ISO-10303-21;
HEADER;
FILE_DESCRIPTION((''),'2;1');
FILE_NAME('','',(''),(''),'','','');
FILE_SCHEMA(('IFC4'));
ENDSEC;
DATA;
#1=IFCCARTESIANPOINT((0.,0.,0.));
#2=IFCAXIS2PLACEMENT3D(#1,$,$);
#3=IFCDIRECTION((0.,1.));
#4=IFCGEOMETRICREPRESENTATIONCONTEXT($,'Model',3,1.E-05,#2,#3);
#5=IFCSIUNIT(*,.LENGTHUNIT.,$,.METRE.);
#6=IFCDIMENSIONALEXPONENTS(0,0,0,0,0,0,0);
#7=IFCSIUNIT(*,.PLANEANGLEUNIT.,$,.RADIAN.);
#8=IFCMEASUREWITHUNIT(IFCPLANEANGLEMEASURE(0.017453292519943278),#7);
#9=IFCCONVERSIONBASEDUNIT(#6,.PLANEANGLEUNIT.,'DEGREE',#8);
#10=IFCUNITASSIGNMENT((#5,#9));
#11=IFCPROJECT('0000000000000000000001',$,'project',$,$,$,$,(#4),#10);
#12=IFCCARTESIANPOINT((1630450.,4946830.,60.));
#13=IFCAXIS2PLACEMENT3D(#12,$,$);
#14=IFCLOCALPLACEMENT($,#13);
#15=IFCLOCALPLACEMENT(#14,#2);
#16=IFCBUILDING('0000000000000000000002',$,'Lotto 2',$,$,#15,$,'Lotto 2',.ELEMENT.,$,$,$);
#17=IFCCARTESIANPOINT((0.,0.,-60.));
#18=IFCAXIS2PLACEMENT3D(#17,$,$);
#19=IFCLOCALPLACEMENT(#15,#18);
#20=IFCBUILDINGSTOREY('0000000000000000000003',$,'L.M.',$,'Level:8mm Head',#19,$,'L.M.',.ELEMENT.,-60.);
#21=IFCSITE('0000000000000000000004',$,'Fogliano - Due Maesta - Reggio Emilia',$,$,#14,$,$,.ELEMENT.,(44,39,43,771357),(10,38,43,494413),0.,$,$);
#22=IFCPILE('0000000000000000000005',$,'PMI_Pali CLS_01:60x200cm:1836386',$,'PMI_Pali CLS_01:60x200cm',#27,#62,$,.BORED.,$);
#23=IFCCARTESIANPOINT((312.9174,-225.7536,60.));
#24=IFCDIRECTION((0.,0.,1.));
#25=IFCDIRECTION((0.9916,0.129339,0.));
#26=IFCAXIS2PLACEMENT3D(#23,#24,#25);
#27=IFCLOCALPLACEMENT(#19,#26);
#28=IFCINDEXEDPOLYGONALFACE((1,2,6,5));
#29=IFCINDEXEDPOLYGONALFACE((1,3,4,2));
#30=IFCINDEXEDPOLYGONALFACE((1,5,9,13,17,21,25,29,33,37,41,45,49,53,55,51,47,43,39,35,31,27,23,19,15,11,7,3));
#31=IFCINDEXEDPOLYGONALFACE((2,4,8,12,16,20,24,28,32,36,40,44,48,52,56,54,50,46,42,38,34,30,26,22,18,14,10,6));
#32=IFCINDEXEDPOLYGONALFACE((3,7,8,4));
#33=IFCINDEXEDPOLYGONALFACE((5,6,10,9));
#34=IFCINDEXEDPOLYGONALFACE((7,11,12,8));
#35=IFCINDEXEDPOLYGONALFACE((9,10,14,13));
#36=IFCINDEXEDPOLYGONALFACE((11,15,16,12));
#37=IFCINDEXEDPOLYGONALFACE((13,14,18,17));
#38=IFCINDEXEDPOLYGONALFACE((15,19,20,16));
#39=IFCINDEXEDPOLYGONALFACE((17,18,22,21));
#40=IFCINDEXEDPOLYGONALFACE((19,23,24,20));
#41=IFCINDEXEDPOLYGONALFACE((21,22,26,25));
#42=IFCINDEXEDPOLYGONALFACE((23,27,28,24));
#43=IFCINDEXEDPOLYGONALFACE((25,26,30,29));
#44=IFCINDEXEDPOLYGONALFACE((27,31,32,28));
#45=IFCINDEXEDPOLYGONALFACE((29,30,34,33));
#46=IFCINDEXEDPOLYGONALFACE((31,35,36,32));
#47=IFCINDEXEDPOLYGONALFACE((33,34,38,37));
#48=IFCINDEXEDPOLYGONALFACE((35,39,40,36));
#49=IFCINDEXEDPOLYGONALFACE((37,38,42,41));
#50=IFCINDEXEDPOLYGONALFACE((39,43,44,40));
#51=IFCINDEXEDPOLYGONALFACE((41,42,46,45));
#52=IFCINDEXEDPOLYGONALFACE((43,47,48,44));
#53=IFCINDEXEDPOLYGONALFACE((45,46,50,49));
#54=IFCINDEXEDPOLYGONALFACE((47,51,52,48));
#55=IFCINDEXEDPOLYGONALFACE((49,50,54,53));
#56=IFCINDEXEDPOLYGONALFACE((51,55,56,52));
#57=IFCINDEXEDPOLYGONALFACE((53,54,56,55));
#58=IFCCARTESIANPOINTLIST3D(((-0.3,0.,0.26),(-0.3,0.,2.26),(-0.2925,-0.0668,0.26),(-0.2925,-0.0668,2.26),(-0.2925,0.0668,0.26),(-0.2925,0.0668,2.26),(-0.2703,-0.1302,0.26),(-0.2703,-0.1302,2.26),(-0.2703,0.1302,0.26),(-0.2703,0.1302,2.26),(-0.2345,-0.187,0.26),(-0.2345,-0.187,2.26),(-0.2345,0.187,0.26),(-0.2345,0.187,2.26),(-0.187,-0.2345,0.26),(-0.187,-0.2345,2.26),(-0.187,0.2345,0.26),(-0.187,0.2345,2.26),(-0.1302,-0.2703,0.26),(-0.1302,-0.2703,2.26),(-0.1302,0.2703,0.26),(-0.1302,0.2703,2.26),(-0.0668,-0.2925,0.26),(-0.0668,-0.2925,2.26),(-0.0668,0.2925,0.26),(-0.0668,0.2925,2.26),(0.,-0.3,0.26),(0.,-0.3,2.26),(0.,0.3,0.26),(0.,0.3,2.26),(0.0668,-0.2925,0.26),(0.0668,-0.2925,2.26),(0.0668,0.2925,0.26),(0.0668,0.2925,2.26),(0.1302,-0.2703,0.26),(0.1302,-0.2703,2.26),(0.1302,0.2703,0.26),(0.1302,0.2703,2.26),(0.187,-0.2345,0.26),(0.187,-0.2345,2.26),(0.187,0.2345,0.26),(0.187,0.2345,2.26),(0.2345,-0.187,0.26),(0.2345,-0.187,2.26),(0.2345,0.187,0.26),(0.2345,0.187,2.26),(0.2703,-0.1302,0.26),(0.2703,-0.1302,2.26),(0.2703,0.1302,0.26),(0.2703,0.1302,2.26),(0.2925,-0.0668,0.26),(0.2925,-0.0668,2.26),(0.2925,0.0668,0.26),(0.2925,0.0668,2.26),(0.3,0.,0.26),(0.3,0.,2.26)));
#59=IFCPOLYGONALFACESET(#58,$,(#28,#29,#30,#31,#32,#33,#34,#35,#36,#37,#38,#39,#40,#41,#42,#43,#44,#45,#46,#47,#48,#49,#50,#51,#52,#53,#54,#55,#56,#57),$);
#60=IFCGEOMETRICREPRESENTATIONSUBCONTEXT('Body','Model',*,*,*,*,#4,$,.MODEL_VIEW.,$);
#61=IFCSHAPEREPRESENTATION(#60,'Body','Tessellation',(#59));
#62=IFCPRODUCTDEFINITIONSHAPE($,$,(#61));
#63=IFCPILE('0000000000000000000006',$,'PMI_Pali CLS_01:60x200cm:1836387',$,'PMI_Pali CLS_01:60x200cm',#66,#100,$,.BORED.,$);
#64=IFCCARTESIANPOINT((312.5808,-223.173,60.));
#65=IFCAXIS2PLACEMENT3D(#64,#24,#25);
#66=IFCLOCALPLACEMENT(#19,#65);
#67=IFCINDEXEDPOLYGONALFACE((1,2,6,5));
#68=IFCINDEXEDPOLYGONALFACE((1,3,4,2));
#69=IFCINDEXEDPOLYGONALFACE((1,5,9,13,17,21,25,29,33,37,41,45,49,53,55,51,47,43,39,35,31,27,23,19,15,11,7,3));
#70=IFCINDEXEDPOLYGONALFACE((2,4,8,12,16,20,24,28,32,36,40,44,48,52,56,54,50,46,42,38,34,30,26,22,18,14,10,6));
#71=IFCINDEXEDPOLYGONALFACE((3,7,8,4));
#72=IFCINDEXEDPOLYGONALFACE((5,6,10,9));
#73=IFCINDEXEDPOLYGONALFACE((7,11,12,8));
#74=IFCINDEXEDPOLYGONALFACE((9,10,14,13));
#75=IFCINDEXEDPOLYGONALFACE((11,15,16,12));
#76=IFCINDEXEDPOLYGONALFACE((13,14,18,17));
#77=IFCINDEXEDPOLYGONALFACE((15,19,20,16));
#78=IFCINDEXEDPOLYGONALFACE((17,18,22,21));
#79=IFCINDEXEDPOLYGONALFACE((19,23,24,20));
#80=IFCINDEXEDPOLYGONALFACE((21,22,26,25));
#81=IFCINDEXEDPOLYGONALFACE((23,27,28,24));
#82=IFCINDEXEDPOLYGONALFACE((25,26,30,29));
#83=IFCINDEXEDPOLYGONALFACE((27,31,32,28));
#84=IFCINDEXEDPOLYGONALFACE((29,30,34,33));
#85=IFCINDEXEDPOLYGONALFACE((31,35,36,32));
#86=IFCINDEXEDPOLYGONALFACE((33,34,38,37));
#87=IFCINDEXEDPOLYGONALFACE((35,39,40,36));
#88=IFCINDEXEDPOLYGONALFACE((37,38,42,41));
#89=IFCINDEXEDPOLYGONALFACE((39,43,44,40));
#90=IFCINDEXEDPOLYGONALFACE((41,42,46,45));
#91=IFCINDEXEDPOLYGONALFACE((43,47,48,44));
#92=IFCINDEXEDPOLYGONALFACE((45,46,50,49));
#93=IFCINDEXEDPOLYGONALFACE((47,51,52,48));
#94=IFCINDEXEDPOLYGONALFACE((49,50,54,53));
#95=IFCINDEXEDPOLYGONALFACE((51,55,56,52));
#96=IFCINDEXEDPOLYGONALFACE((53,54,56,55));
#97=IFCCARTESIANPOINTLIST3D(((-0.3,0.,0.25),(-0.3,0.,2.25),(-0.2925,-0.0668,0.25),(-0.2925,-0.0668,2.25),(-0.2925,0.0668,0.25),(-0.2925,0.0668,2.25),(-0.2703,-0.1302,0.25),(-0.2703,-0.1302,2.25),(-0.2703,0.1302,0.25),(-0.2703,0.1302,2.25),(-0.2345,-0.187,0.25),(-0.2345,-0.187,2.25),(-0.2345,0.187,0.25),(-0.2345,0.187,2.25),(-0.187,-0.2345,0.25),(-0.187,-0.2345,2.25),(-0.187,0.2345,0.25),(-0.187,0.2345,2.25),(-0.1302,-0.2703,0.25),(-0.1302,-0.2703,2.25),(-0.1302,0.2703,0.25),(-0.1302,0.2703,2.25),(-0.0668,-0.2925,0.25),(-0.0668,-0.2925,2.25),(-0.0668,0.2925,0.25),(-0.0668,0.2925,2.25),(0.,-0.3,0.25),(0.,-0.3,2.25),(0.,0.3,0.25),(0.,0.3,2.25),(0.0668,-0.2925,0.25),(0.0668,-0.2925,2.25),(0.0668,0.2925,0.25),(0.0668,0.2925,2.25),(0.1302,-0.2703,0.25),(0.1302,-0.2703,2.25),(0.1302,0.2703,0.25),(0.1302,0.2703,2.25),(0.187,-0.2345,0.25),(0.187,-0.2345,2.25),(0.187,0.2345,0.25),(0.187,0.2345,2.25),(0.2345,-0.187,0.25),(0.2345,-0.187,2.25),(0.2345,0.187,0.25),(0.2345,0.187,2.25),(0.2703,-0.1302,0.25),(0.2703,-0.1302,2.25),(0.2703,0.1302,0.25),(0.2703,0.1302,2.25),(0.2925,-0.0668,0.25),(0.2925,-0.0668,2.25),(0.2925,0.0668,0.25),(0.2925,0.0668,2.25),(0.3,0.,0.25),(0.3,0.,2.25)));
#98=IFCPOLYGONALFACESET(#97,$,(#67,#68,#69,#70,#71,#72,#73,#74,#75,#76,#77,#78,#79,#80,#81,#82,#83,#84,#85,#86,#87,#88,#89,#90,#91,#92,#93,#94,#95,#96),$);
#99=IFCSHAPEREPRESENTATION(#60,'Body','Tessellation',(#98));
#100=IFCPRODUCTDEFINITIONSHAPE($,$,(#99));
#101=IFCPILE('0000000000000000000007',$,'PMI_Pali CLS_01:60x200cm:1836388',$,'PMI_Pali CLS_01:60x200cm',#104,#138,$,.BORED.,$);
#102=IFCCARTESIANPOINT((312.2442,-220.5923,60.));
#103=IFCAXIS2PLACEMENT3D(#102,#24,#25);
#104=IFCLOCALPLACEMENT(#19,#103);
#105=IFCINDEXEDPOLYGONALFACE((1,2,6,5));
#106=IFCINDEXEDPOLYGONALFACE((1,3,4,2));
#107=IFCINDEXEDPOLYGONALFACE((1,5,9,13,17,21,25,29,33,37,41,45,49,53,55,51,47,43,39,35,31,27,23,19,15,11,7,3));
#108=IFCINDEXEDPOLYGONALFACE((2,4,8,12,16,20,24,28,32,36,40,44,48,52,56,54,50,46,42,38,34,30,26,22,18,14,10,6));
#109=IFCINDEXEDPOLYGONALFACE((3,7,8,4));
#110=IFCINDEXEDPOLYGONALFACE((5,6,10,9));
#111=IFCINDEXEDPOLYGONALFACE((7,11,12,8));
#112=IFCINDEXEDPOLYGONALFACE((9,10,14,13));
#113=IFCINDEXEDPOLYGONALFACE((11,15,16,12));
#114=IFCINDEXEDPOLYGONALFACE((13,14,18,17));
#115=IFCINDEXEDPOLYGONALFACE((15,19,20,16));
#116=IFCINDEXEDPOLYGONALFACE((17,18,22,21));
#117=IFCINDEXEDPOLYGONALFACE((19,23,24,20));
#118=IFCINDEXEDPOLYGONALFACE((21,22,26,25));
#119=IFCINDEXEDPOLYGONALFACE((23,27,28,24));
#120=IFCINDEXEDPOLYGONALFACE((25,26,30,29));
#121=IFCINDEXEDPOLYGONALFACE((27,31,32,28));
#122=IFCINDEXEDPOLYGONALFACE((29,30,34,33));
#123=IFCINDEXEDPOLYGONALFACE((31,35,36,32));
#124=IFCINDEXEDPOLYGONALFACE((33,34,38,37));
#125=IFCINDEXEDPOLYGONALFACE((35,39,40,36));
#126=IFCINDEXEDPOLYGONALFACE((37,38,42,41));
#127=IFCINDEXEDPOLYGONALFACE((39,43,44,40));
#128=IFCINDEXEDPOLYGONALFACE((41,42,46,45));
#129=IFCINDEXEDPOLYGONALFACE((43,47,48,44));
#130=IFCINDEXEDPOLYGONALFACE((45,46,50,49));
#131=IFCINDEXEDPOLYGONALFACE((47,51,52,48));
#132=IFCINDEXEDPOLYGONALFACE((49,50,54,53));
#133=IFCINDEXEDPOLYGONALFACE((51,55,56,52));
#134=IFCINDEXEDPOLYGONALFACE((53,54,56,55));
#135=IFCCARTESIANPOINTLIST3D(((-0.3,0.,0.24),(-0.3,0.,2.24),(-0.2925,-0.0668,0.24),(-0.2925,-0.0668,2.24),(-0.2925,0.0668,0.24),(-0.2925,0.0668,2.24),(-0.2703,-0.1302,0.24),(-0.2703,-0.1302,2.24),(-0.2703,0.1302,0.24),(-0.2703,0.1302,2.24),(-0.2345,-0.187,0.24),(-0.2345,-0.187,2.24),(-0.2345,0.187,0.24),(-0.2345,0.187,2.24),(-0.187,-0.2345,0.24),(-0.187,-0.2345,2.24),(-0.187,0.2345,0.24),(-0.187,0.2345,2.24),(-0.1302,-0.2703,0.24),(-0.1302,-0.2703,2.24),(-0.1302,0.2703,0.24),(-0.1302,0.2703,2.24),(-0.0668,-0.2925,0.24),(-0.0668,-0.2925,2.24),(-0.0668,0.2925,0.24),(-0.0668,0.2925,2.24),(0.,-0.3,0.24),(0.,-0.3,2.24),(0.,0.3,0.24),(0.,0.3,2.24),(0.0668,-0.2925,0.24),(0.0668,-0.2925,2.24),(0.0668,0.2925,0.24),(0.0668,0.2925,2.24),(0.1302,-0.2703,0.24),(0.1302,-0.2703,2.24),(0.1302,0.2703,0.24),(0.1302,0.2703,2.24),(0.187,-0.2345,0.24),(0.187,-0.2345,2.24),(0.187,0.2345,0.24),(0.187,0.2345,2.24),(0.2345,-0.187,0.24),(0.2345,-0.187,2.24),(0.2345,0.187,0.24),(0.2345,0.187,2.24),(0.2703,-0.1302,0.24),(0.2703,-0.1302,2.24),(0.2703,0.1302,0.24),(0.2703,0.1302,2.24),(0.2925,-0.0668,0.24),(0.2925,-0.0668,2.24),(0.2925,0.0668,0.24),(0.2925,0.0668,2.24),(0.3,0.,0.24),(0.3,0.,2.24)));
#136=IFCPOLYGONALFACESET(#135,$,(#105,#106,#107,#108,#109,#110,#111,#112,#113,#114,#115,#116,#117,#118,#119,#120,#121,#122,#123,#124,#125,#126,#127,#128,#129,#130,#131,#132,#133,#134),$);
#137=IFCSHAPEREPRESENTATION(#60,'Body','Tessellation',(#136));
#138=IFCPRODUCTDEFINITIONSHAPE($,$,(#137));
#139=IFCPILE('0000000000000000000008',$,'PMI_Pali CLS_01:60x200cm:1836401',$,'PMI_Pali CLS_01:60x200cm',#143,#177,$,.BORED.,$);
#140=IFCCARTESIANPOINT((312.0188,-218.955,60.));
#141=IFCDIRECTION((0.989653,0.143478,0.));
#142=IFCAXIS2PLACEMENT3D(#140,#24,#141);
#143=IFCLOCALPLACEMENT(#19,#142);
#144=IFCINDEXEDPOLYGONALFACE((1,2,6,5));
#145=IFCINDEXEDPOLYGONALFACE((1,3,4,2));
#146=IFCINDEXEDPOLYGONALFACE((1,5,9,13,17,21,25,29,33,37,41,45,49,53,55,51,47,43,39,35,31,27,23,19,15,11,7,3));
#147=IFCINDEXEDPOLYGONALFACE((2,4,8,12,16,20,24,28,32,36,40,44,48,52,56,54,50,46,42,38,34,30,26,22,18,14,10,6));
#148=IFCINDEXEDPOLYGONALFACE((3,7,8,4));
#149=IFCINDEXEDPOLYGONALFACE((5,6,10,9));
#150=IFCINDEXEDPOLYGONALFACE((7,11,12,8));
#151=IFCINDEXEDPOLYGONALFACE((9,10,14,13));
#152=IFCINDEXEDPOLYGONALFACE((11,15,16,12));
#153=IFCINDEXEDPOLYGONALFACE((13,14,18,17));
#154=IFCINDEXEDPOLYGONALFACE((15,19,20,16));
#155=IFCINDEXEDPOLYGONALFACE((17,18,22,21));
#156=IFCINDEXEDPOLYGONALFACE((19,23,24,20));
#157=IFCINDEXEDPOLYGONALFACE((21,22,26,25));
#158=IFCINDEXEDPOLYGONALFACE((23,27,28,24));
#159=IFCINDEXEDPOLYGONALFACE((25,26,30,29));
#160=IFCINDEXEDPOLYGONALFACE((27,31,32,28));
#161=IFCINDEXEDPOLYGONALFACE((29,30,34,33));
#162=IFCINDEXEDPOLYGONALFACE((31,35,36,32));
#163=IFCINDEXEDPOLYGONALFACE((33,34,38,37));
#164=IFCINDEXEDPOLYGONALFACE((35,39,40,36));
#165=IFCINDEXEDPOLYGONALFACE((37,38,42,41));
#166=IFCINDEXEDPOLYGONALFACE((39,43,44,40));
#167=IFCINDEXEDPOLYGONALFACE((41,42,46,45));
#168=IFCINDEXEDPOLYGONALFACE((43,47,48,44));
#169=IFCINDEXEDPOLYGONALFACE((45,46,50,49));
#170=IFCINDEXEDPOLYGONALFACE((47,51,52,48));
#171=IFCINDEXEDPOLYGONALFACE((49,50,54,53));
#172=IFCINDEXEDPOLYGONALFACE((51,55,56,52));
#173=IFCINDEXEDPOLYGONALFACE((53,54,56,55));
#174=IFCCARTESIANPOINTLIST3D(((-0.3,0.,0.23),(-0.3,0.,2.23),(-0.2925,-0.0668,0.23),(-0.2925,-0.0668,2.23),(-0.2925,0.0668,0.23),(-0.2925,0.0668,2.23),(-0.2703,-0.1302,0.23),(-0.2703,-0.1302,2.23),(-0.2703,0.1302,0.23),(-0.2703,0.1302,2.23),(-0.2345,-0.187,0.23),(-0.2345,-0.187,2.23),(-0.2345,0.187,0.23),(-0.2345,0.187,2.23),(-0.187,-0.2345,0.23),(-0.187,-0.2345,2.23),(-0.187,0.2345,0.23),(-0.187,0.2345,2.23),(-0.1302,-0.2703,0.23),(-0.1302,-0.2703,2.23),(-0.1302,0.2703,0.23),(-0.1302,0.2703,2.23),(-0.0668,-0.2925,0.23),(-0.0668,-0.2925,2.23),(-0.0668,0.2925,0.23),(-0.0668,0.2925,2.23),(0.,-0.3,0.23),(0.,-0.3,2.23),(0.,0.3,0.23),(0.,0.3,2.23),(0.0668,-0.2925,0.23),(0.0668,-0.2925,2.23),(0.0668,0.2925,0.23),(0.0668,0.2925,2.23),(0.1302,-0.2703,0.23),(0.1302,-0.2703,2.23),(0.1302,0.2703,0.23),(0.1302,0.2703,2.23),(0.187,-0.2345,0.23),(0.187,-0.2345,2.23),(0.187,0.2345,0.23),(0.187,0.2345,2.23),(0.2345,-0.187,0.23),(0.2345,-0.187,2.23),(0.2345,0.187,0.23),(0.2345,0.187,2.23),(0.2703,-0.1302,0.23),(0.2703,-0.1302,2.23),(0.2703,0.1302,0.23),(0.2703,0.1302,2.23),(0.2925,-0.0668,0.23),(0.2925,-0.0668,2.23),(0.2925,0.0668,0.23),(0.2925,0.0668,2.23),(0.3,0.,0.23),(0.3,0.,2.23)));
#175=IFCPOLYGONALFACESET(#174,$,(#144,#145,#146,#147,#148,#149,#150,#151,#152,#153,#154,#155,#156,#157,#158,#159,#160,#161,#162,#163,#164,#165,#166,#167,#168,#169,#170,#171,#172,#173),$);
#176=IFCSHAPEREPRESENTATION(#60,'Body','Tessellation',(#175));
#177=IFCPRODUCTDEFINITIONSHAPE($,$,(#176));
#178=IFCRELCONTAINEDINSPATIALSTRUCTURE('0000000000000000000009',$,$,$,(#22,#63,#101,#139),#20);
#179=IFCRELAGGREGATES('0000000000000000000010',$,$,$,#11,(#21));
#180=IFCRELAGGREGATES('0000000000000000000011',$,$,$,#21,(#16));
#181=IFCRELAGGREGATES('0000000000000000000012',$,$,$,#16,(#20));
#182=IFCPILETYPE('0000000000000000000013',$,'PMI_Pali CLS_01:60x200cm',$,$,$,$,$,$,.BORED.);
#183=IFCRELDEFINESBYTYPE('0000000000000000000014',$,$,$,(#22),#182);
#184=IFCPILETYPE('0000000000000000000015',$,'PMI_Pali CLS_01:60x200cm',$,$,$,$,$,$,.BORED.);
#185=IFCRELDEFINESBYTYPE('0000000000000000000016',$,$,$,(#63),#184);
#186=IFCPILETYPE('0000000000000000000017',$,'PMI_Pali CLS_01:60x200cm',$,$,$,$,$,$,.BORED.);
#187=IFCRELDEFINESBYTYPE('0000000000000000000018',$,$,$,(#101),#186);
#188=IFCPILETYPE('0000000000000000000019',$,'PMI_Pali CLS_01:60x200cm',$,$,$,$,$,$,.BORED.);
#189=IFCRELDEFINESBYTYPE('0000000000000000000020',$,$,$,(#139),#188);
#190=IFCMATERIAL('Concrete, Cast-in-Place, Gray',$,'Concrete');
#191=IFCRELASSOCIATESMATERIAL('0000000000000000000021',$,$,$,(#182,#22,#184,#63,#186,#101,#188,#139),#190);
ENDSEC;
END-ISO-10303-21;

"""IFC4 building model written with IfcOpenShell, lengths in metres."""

from ifc_helpers import new_model, entity, si_unit, converted_unit, direction, frame, origin, place, context, subcontext, project, spatial, arc, indexed_curve, outline, extrude, source, transform, mapped, material, type_object, type_shapes, element, save


model = new_model("IFC4")

# Units and contexts
model_context = context("Model", 3, precision=1e-05, world=origin(), true_north=direction((0.0, 1.0)))
body_context = subcontext(model_context, "Body", "Model", "MODEL_VIEW")
ifc_project = project(units=[si_unit("LENGTHUNIT", "METRE"), converted_unit("PLANEANGLEUNIT", "DEGREE", entity("IfcPlaneAngleMeasure", 0.017453292519943278), si_unit("PLANEANGLEUNIT", "RADIAN"), dimensions=[0, 0, 0, 0, 0, 0, 0])], contexts=[model_context])

# Site, building, storey
site_placement = place(None, frame((1630450.0, 4946830.0, 60.0)))
site = spatial("IfcSite", under=ifc_project, at=site_placement, Name="Fogliano - Due Maesta - Reggio Emilia", CompositionType="ELEMENT", RefLatitude=(44, 39, 43, 771357), RefLongitude=(10, 38, 43, 494413), RefElevation=0.0)
building_placement = place(site_placement, origin())
building = spatial("IfcBuilding", under=site, at=building_placement, Name="Lotto 2", LongName="Lotto 2", CompositionType="ELEMENT")
storey_placement = place(building_placement, frame((0.0, 0.0, -60.0)))
storey = spatial("IfcBuildingStorey", under=building, at=storey_placement, Name="L.M.", ObjectType="Level:8mm Head", LongName="L.M.", CompositionType="ELEMENT", Elevation=-60.0)

# Piles
ifc_material_1 = material(Name="Concrete, Cast-in-Place, Gray", Category="Concrete")
pile_type_1 = type_object("IfcPileType", Name="PMI_Pali CLS_01:60x200cm", PredefinedType="BORED", material=ifc_material_1)
shared_shape_1 = source(origin(), body_context, "Body", "SweptSolid", [
    extrude(outline(indexed_curve([(-0.3, 0.0), (0.0, -0.3), (0.3, 0.0), (0.0, 0.3)], segments=[arc(1, 2, 3), arc(3, 4, 1)], self_intersect=False)), frame((0.0, 0.0, 0.26)), (0.0, 0.0, 1.0), 2.0),
])
type_shapes(pile_type_1, [shared_shape_1])
pile_1_placement = place(storey_placement, frame((312.9174, -225.7536, 60.0), z_axis=(0.0, 0.0, 1.0), x_axis=(0.9916, 0.129339, 0.0)))
element("IfcPile", 1, at=pile_1_placement, inside=storey, type_object=pile_type_1, material=ifc_material_1, Name="PMI_Pali CLS_01:60x200cm:1836386", ObjectType="PMI_Pali CLS_01:60x200cm", PredefinedType="BORED", context=body_context, shape_type="MappedRepresentation", body=[
    mapped(shared_shape_1, transform((0.0, 0.0, 0.0), scale=1.0)),
])
pile_type_2 = type_object("IfcPileType", Name="PMI_Pali CLS_01:60x200cm", PredefinedType="BORED", material=ifc_material_1)
shared_shape_2 = source(origin(), body_context, "Body", "SweptSolid", [
    extrude(outline(indexed_curve([(-0.3, 0.0), (0.0, -0.3), (0.3, 0.0), (0.0, 0.3)], segments=[arc(1, 2, 3), arc(3, 4, 1)], self_intersect=False)), frame((0.0, 0.0, 0.25)), (0.0, 0.0, 1.0), 2.0),
])
type_shapes(pile_type_2, [shared_shape_2])
pile_2_placement = place(storey_placement, frame((312.5808, -223.173, 60.0), z_axis=(0.0, 0.0, 1.0), x_axis=(0.9916, 0.129339, 0.0)))
element("IfcPile", 2, at=pile_2_placement, inside=storey, type_object=pile_type_2, material=ifc_material_1, Name="PMI_Pali CLS_01:60x200cm:1836387", ObjectType="PMI_Pali CLS_01:60x200cm", PredefinedType="BORED", context=body_context, shape_type="MappedRepresentation", body=[
    mapped(shared_shape_2, transform((0.0, 0.0, 0.0), scale=1.0)),
])
pile_type_3 = type_object("IfcPileType", Name="PMI_Pali CLS_01:60x200cm", PredefinedType="BORED", material=ifc_material_1)
shared_shape_3 = source(origin(), body_context, "Body", "SweptSolid", [
    extrude(outline(indexed_curve([(-0.3, 0.0), (0.0, -0.3), (0.3, 0.0), (0.0, 0.3)], segments=[arc(1, 2, 3), arc(3, 4, 1)], self_intersect=False)), frame((0.0, 0.0, 0.24)), (0.0, 0.0, 1.0), 2.0),
])
type_shapes(pile_type_3, [shared_shape_3])
pile_3_placement = place(storey_placement, frame((312.2442, -220.5923, 60.0), z_axis=(0.0, 0.0, 1.0), x_axis=(0.9916, 0.129339, 0.0)))
element("IfcPile", 3, at=pile_3_placement, inside=storey, type_object=pile_type_3, material=ifc_material_1, Name="PMI_Pali CLS_01:60x200cm:1836388", ObjectType="PMI_Pali CLS_01:60x200cm", PredefinedType="BORED", context=body_context, shape_type="MappedRepresentation", body=[
    mapped(shared_shape_3, transform((0.0, 0.0, 0.0), scale=1.0)),
])
pile_type_4 = type_object("IfcPileType", Name="PMI_Pali CLS_01:60x200cm", PredefinedType="BORED", material=ifc_material_1)
shared_shape_4 = source(origin(), body_context, "Body", "SweptSolid", [
    extrude(outline(indexed_curve([(-0.3, 0.0), (0.0, -0.3), (0.3, 0.0), (0.0, 0.3)], segments=[arc(1, 2, 3), arc(3, 4, 1)], self_intersect=False)), frame((0.0, 0.0, 0.23)), (0.0, 0.0, 1.0), 2.0),
])
type_shapes(pile_type_4, [shared_shape_4])
pile_4_placement = place(storey_placement, frame((312.0188, -218.955, 60.0), z_axis=(0.0, 0.0, 1.0), x_axis=(0.989653, 0.143478, 0.0)))
element("IfcPile", 4, at=pile_4_placement, inside=storey, type_object=pile_type_4, material=ifc_material_1, Name="PMI_Pali CLS_01:60x200cm:1836401", ObjectType="PMI_Pali CLS_01:60x200cm", PredefinedType="BORED", context=body_context, shape_type="MappedRepresentation", body=[
    mapped(shared_shape_4, transform((0.0, 0.0, 0.0), scale=1.0)),
])

save(model, "model.ifc")
